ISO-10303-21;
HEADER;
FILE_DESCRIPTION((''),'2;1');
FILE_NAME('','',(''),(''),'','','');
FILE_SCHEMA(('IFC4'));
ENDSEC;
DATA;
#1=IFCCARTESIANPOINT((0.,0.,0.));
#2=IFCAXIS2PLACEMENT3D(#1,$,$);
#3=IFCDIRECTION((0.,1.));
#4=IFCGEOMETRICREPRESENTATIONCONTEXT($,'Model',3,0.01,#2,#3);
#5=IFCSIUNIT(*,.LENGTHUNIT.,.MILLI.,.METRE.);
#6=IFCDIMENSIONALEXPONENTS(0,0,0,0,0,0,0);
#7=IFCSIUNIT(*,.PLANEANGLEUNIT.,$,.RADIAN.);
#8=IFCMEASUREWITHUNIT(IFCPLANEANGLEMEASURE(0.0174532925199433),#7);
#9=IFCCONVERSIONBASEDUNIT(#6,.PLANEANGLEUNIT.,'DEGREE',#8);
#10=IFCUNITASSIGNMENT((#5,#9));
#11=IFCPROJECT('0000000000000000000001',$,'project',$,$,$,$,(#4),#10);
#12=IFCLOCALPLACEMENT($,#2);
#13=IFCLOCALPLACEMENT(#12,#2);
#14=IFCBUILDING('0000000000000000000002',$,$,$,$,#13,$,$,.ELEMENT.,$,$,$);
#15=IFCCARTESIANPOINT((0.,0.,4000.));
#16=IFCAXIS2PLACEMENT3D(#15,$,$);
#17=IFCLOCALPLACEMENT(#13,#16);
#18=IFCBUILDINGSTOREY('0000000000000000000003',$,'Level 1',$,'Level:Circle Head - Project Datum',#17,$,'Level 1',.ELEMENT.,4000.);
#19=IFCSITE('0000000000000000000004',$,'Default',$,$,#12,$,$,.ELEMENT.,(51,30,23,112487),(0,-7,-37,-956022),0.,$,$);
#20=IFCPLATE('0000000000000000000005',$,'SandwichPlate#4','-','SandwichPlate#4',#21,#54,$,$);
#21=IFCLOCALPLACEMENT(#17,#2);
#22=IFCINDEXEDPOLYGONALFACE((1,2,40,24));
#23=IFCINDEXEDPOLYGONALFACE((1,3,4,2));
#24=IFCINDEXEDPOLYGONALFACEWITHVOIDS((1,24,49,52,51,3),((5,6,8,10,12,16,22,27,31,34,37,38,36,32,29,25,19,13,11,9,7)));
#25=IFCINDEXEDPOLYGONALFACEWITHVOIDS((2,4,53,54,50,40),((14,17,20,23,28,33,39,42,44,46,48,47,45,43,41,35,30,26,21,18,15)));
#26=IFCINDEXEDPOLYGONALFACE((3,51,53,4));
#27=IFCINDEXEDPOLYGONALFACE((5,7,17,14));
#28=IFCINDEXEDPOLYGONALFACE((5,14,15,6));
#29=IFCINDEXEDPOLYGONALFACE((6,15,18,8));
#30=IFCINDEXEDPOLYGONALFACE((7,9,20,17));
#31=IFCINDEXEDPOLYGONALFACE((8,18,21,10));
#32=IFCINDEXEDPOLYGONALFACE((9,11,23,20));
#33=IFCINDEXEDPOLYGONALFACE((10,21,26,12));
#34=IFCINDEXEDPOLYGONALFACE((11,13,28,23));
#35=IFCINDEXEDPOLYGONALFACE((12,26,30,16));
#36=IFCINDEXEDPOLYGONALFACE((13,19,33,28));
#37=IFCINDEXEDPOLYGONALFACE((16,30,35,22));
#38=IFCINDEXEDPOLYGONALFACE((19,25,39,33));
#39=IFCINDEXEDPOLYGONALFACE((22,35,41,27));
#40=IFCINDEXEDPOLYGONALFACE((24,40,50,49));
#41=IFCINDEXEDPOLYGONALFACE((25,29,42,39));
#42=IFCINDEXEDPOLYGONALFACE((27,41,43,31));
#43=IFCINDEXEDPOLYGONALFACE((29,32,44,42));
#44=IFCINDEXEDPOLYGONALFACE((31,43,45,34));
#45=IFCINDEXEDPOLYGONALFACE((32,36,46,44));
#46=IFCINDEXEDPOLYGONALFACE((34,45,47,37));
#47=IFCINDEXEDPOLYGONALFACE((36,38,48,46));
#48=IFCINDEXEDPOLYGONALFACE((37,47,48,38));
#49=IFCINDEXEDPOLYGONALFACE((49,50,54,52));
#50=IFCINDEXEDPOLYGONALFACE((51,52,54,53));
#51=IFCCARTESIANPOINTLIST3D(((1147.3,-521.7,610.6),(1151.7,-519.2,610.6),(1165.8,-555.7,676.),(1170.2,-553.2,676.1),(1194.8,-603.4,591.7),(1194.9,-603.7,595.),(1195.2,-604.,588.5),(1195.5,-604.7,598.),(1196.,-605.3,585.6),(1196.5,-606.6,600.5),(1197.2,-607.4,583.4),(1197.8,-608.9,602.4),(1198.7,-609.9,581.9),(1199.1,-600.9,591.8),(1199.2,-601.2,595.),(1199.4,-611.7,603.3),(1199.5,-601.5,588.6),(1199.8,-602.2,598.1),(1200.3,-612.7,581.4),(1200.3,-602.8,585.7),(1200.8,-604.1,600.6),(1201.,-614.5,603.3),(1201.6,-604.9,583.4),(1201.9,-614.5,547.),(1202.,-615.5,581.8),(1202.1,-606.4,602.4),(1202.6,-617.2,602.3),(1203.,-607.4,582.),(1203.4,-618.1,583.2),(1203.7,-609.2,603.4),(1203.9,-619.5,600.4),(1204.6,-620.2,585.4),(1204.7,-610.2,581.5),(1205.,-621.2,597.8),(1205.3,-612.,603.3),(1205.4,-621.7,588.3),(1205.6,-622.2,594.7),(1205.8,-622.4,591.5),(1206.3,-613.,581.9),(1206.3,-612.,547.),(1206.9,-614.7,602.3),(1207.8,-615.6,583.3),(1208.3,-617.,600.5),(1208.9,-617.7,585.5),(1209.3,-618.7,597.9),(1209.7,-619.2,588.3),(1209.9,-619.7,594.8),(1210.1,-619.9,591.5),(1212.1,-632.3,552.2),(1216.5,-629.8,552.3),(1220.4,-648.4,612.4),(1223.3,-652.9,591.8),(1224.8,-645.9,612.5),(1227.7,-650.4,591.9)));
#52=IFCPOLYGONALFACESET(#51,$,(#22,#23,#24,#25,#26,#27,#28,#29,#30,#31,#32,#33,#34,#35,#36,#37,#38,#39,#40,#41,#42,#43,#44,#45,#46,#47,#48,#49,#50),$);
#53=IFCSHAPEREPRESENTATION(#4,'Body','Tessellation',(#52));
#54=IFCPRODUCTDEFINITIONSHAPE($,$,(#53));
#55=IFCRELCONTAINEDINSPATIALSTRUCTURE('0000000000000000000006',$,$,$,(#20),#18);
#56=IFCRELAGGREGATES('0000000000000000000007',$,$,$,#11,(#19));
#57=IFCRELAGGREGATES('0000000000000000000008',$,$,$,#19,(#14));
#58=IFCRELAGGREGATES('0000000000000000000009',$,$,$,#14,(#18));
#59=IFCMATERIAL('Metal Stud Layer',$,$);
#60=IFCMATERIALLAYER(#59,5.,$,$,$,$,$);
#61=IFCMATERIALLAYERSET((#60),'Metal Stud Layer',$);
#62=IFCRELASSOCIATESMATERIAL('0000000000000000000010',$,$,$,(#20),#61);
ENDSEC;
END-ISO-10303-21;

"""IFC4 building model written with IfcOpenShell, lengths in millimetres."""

from ifc_helpers import new_model, entity, si_unit, converted_unit, direction, frame, origin, origin_with_axes, origin_2d_with_axis, place, context, project, spatial, polyline, circle, outline, extrude, material, layer, layer_set, element, save


model = new_model("IFC4")

# Units and contexts
model_context = context("Model", 3, precision=0.01, world=origin(), true_north=direction((0.0, 1.0)))
ifc_project = project(units=[si_unit("LENGTHUNIT", "METRE", prefix="MILLI"), converted_unit("PLANEANGLEUNIT", "DEGREE", entity("IfcPlaneAngleMeasure", 0.0174532925199433), si_unit("PLANEANGLEUNIT", "RADIAN"), dimensions=[0, 0, 0, 0, 0, 0, 0])], contexts=[model_context])

# Site, building, storey
site_placement = place(None, origin())
site = spatial("IfcSite", under=ifc_project, at=site_placement, Name="Default", CompositionType="ELEMENT", RefLatitude=(51, 30, 23, 112487), RefLongitude=(0, -7, -37, -956022), RefElevation=0.0)
building_placement = place(site_placement, origin())
building = spatial("IfcBuilding", under=site, at=building_placement, CompositionType="ELEMENT")
storey_placement = place(building_placement, frame((0.0, 0.0, 4000.0)))
storey = spatial("IfcBuildingStorey", under=building, at=storey_placement, Name="Level 1", ObjectType="Level:Circle Head - Project Datum", LongName="Level 1", CompositionType="ELEMENT", Elevation=4000.0)

# Shared definitions
ifc_material_1 = material(Name="Metal Stud Layer")

# Shared definitions
ifc_layer_1 = layer(ifc_material_1, 5.0)
ifc_layer_set_1 = layer_set([ifc_layer_1], Name="Metal Stud Layer")

# Plate, openings
plate_1_placement = place(storey_placement, frame((1212.8, -623.1, 539.4), z_axis=(-0.865935, -0.499948, -0.014432), x_axis=(0.243701, -0.44695, 0.860724)))
plate_1 = element("IfcPlate", 1, at=plate_1_placement, inside=storey, material=ifc_layer_set_1, Name="SandwichPlate#4", Description="-", ObjectType="SandwichPlate#4", context=model_context, shape_type="SweptSolid", body=[
    extrude(outline(polyline([(0.0, 0.0), (76.0, 0.0), (76.0, 140.0), (0.0, 140.0), (0.0, 0.0)])), origin_with_axes(), (0.0, 0.0, 1.0), 5.0),
])
opening_1_placement = place(plate_1_placement, frame((0.0, 0.0, 0.0), z_axis=(0.0, 0.0, 1.0), x_axis=(1.0, 0.0, 0.0)))
element("IfcOpeningElement", 2, at=opening_1_placement, cuts=plate_1, ObjectType="Opening", context=model_context, shape_type="SweptSolid", body=[
    extrude(outline(polyline([(0.0, 0.0), (15.0, 0.0), (0.0, 15.0), (0.0, 0.0)])), origin(), (0.0, 0.0, 1.0), 5.0),
])
opening_2_placement = place(plate_1_placement, frame((0.0, 0.0, 0.0), z_axis=(0.0, 0.0, 1.0), x_axis=(1.0, 0.0, 0.0)))
element("IfcOpeningElement", 3, at=opening_2_placement, cuts=plate_1, ObjectType="Opening", context=model_context, shape_type="SweptSolid", body=[
    extrude(outline(polyline([(76.0, 0.0), (76.0, 15.0), (61.0, 0.0), (76.0, 0.0)])), origin(), (0.0, 0.0, 1.0), 5.0),
])
opening_3_placement = place(plate_1_placement, frame((38.0, 40.0, -0.5), z_axis=(0.0, 0.0, 1.0), x_axis=(0.0, 1.0, 0.0)))
element("IfcOpeningElement", 4, at=opening_3_placement, cuts=plate_1, ObjectType="Opening", context=model_context, shape_type="SweptSolid", body=[
    extrude(circle(Radius=11.0, at=origin_2d_with_axis()), origin(), (0.0, 0.0, 1.0), 6.0),
])

save(model, "model.ifc")
